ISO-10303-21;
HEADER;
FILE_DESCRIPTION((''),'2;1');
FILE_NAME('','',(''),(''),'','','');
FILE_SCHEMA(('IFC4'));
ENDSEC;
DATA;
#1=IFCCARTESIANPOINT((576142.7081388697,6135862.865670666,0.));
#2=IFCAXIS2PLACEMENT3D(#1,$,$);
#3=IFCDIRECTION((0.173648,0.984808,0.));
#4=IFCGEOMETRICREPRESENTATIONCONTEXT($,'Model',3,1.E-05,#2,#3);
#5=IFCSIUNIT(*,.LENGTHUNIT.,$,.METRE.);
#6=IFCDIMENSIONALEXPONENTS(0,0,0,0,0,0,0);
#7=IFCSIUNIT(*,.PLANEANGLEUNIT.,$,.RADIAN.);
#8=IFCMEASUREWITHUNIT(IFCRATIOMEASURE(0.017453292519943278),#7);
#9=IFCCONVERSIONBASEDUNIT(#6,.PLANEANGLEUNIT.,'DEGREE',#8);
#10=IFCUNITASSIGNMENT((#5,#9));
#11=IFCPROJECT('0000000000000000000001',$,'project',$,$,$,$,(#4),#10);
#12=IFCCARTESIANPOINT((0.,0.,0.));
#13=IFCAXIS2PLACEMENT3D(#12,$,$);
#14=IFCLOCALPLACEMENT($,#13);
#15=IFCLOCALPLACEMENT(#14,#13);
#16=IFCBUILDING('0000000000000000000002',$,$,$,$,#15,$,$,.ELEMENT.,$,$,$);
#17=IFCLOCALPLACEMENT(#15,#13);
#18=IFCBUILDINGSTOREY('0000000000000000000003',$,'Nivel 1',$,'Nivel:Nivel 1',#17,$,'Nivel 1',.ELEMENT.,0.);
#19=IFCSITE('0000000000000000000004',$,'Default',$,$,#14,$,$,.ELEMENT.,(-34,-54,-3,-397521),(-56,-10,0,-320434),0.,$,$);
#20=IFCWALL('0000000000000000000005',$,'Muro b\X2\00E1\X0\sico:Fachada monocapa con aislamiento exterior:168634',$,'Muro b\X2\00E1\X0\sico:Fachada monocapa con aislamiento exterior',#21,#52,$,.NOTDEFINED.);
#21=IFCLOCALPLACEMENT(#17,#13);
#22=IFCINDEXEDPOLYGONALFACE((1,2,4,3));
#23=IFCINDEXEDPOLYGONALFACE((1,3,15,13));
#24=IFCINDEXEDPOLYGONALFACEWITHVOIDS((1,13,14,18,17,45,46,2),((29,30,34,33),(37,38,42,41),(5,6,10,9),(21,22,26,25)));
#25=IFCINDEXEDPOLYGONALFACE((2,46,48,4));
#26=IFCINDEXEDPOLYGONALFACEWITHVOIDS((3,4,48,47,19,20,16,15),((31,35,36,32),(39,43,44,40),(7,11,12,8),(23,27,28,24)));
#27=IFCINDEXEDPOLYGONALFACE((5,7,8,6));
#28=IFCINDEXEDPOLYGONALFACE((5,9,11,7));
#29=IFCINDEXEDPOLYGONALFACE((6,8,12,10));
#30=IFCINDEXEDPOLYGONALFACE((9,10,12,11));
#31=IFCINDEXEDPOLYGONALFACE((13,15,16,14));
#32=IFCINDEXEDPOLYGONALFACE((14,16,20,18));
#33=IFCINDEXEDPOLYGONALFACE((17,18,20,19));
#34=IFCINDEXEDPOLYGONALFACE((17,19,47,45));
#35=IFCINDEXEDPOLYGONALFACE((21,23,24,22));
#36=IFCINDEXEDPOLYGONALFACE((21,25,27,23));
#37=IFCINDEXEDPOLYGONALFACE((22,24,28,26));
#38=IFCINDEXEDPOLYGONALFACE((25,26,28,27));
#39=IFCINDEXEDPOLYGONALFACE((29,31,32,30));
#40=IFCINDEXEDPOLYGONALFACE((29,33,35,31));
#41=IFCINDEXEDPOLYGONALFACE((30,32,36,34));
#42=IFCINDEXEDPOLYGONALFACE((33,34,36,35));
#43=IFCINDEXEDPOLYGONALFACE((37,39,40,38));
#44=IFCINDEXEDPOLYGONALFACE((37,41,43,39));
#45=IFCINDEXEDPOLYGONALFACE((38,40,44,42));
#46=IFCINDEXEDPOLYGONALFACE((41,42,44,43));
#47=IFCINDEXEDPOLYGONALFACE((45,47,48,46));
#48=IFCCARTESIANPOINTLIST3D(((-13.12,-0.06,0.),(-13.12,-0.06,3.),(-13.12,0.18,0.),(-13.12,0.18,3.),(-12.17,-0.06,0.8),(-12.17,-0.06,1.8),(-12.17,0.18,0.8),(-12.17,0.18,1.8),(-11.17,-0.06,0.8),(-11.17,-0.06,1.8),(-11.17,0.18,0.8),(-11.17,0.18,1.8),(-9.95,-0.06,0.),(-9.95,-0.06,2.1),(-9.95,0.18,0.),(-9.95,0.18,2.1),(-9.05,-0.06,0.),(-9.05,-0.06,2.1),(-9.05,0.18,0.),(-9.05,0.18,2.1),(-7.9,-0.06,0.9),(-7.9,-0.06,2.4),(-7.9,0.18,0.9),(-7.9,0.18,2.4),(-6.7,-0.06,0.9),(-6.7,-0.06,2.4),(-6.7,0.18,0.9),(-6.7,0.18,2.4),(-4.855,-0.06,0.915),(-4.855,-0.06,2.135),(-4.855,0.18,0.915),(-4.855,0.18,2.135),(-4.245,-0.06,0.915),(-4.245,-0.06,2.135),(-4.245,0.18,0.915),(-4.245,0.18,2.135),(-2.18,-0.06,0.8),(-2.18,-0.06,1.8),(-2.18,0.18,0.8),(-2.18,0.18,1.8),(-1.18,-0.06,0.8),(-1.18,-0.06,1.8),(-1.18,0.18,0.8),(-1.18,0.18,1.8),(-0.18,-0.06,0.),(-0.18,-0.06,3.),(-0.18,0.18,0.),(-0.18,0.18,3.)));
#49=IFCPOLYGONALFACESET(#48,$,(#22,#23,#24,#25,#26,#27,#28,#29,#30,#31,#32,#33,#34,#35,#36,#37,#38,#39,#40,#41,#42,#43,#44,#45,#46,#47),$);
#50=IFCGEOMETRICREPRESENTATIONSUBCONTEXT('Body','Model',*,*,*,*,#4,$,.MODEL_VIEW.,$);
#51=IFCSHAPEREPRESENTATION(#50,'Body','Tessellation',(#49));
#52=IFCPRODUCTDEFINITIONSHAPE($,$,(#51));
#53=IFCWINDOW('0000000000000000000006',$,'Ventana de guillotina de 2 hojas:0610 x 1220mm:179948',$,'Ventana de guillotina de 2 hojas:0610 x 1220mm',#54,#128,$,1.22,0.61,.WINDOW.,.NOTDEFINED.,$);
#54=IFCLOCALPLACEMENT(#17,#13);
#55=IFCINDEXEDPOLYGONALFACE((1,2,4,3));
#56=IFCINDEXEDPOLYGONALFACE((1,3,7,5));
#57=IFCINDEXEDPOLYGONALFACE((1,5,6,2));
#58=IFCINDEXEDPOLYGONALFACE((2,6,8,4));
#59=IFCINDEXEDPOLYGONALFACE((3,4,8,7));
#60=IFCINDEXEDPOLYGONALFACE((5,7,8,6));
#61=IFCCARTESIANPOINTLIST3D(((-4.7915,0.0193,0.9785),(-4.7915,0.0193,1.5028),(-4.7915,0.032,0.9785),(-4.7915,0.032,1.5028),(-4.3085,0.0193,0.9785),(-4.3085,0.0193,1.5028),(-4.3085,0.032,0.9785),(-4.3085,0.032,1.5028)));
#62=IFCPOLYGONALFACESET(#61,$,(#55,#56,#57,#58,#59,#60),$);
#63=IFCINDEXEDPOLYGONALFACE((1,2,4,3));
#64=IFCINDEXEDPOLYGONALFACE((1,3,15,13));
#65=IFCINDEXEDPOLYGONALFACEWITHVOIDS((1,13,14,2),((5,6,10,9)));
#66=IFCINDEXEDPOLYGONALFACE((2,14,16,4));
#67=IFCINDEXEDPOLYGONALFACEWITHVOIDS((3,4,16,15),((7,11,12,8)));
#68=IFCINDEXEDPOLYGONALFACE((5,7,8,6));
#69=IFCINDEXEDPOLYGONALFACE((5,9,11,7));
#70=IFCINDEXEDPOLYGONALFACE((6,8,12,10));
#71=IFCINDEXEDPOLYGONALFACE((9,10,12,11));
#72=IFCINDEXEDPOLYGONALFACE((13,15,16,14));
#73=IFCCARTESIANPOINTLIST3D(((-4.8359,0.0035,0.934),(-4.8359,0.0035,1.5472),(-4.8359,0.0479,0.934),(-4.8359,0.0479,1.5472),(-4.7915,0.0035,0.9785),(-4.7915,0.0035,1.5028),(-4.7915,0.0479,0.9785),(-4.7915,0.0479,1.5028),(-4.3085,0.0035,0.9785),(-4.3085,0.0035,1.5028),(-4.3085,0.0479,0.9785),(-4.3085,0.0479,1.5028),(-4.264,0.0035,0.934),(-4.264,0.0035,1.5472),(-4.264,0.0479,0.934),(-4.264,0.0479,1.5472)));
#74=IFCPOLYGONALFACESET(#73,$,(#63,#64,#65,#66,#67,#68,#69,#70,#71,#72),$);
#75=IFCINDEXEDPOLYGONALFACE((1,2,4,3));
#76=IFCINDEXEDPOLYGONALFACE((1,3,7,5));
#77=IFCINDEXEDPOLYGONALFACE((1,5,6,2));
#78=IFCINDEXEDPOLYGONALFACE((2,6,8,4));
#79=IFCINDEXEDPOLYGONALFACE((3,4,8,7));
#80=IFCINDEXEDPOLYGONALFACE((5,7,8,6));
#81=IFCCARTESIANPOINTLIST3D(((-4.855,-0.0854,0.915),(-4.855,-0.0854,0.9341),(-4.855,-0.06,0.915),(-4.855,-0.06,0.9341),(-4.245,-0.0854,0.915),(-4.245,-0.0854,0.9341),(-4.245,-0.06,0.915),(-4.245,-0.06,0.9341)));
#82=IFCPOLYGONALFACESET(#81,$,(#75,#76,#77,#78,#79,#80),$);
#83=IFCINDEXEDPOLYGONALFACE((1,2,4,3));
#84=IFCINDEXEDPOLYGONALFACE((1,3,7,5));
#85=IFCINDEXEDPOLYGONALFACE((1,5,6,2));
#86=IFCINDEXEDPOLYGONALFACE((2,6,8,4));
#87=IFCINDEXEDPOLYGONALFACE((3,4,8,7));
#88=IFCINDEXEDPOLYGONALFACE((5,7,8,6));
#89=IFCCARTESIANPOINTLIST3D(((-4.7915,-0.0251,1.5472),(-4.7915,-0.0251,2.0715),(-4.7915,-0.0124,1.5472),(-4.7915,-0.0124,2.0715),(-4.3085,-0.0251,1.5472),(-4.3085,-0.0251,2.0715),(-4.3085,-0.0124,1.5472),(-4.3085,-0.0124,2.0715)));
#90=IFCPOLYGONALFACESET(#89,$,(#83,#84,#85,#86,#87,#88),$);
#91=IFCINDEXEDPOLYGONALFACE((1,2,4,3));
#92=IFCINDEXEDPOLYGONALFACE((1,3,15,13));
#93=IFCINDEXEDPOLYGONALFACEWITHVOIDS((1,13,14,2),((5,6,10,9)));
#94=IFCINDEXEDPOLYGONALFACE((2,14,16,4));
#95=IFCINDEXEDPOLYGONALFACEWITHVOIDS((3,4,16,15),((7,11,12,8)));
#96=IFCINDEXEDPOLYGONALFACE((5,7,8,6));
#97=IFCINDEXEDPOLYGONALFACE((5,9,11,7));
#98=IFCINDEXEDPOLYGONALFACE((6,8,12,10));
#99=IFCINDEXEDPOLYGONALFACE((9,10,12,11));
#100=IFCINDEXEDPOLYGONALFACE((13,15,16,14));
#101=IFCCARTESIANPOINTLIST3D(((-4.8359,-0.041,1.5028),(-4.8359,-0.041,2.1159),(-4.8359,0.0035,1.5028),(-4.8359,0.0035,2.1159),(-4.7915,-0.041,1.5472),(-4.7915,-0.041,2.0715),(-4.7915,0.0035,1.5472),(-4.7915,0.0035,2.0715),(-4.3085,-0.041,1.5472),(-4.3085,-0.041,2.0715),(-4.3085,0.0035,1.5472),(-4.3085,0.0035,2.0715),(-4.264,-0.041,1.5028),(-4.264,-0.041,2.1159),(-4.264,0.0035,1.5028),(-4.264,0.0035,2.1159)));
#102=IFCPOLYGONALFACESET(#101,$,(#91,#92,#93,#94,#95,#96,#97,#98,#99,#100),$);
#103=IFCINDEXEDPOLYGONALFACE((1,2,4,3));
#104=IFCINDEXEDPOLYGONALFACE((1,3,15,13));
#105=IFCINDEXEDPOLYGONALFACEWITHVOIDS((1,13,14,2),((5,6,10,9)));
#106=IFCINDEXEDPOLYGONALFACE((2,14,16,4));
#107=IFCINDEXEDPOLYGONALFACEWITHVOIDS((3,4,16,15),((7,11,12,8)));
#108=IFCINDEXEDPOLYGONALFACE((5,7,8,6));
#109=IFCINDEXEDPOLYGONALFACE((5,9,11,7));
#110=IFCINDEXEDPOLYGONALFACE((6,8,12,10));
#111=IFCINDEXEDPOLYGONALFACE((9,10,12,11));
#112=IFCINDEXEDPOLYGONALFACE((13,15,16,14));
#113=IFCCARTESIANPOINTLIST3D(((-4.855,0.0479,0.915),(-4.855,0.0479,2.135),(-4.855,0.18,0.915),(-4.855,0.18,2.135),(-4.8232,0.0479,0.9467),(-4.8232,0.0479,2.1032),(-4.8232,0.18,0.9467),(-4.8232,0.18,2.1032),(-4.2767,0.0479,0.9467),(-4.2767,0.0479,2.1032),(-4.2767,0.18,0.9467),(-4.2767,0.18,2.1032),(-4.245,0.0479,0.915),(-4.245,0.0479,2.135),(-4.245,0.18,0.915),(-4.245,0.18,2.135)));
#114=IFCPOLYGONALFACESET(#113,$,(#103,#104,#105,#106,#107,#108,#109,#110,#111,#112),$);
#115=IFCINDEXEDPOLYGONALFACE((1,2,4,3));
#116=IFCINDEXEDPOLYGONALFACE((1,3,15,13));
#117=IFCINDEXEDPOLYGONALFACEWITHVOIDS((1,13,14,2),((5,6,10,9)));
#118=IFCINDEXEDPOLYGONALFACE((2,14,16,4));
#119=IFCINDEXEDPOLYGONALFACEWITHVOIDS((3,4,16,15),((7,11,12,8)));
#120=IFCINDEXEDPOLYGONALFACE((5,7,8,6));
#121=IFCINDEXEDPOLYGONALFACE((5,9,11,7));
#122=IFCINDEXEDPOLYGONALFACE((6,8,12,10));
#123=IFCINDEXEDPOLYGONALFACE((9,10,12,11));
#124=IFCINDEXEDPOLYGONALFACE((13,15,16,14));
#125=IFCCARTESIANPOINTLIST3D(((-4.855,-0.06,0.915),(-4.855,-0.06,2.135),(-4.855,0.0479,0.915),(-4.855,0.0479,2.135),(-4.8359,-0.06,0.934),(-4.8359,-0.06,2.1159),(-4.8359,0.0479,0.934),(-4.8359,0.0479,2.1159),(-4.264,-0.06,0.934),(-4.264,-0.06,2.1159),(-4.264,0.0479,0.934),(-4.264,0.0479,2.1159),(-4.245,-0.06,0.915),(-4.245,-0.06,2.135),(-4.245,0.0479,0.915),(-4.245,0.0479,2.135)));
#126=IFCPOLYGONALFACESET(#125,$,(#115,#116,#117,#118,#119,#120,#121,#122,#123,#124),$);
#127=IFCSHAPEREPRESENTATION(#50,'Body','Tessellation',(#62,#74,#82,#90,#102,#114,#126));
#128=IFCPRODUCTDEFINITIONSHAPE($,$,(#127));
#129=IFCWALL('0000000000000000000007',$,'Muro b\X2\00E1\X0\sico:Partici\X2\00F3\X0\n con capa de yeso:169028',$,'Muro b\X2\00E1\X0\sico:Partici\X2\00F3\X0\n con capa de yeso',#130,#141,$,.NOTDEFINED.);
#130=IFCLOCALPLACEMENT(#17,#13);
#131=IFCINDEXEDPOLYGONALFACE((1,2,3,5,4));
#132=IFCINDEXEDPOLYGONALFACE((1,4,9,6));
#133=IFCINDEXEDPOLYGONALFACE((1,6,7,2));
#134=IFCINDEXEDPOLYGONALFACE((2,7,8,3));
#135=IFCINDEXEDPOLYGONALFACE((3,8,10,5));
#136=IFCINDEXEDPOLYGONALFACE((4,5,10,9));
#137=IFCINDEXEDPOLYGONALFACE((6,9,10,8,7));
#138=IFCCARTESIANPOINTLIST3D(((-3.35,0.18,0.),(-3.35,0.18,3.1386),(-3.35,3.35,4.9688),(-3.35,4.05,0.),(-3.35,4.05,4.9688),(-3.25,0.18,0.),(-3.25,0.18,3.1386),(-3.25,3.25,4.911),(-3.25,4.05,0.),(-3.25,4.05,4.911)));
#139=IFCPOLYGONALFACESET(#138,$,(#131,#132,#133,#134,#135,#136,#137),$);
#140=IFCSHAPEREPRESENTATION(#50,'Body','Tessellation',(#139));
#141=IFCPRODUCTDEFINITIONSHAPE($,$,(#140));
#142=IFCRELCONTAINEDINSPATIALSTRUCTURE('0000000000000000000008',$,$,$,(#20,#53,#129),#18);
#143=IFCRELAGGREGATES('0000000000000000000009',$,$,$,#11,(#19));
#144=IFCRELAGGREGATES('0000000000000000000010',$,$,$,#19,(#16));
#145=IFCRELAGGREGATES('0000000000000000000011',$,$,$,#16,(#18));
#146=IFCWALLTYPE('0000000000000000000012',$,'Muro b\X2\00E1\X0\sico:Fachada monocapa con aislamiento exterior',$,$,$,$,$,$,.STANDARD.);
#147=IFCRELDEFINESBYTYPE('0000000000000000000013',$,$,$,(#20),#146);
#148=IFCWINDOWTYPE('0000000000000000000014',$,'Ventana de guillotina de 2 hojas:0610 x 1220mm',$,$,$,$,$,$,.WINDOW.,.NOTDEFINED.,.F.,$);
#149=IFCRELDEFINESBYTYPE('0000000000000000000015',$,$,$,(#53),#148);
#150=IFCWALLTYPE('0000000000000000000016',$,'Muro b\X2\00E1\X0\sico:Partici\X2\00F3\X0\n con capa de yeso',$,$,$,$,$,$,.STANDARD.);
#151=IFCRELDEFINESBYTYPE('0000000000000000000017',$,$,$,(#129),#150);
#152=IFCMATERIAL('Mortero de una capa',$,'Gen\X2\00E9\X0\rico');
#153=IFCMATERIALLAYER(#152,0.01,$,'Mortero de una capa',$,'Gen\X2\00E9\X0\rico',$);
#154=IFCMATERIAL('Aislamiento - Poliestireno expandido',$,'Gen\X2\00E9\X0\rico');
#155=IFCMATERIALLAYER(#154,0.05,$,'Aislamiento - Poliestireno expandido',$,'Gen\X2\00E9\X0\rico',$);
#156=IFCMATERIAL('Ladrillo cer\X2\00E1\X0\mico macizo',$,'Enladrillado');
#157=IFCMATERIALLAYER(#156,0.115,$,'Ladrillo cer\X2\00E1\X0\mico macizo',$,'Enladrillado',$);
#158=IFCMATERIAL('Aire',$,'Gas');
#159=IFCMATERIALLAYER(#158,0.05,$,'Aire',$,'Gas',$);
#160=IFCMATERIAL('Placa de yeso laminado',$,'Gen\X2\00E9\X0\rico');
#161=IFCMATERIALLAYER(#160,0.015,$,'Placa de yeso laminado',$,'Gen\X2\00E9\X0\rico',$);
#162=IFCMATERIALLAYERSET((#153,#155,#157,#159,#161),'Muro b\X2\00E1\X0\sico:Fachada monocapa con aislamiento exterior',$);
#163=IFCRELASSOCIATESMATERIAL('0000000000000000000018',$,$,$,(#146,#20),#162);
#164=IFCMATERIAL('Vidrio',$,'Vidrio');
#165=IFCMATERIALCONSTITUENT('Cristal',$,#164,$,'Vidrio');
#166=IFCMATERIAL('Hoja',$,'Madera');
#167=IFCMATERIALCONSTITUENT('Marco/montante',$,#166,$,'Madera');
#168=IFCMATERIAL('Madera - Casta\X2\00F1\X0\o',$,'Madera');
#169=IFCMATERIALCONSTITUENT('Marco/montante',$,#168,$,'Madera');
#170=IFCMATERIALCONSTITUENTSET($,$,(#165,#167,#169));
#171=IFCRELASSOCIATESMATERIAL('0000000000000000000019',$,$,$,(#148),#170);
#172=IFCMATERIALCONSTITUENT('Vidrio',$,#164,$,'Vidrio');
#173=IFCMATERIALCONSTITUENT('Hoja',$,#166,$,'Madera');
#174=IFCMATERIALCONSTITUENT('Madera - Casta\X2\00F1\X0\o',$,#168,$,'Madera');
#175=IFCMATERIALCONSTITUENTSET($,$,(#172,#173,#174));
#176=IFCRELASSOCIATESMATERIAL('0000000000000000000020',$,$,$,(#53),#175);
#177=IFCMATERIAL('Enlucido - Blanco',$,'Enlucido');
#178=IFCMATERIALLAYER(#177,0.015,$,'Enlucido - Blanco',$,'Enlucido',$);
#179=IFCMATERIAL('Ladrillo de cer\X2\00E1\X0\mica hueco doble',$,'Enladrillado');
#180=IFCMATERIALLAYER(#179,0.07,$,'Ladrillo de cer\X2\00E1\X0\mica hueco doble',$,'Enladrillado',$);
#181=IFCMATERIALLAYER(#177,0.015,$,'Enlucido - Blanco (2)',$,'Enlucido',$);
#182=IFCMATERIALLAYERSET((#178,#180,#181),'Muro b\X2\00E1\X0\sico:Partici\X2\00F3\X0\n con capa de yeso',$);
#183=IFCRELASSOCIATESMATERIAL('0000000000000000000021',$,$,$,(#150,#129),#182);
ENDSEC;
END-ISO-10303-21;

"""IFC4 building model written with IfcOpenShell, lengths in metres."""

from ifc_helpers import new_model, entity, si_unit, converted_unit, direction, frame, frame_2d, origin, place, context, subcontext, project, spatial, polyline, rectangle, outline, extrude, clip, bounded_halfspace, source, transform, mapped, material, layer, layer_set, layer_usage, constituent, constituent_set, type_object, type_shapes, element, fill, save


model = new_model("IFC4")

# Units and contexts
model_context = context("Model", 3, precision=1e-05, world=frame((576142.7081388697, 6135862.865670666, 0.0)), true_north=direction((0.173648, 0.984808, 0.0)))
body_context = subcontext(model_context, "Body", "Model", "MODEL_VIEW")
ifc_project = project(units=[si_unit("LENGTHUNIT", "METRE"), converted_unit("PLANEANGLEUNIT", "DEGREE", entity("IfcRatioMeasure", 0.017453292519943278), si_unit("PLANEANGLEUNIT", "RADIAN"), dimensions=[0, 0, 0, 0, 0, 0, 0])], contexts=[model_context])

# Site, building, storey
site_placement = place(None, origin())
site = spatial("IfcSite", under=ifc_project, at=site_placement, Name="Default", CompositionType="ELEMENT", RefLatitude=(-34, -54, -3, -397521), RefLongitude=(-56, -10, 0, -320434), RefElevation=0.0)
building_placement = place(site_placement, origin())
building = spatial("IfcBuilding", under=site, at=building_placement, CompositionType="ELEMENT")
storey_placement = place(building_placement, origin())
storey = spatial("IfcBuildingStorey", under=building, at=storey_placement, Name="Nivel 1", ObjectType="Nivel:Nivel 1", LongName="Nivel 1", CompositionType="ELEMENT", Elevation=0.0)

# Shared definitions
ifc_material_1 = material(Name="Mortero de una capa", Category="Genérico")
ifc_layer_1 = layer(ifc_material_1, 0.01, Name="Mortero de una capa", Category="Genérico")
ifc_material_2 = material(Name="Aislamiento - Poliestireno expandido", Category="Genérico")
ifc_layer_2 = layer(ifc_material_2, 0.05, Name="Aislamiento - Poliestireno expandido", Category="Genérico")
ifc_material_3 = material(Name="Ladrillo cerámico macizo", Category="Enladrillado")
ifc_layer_3 = layer(ifc_material_3, 0.115, Name="Ladrillo cerámico macizo", Category="Enladrillado")
ifc_material_4 = material(Name="Aire", Category="Gas")
ifc_layer_4 = layer(ifc_material_4, 0.05, Name="Aire", Category="Gas")
ifc_material_5 = material(Name="Placa de yeso laminado", Category="Genérico")
ifc_layer_5 = layer(ifc_material_5, 0.015, Name="Placa de yeso laminado", Category="Genérico")
ifc_layer_set_1 = layer_set([ifc_layer_1, ifc_layer_2, ifc_layer_3, ifc_layer_4, ifc_layer_5], Name="Muro básico:Fachada monocapa con aislamiento exterior")
ifc_layer_usage_1 = layer_usage(ifc_layer_set_1, "AXIS2", "NEGATIVE", 0.12)
wall_type_1 = type_object("IfcWallType", Name="Muro básico:Fachada monocapa con aislamiento exterior", PredefinedType="STANDARD", material=ifc_layer_set_1)

# Wall, openings, window
wall_1_placement = place(storey_placement, frame((-0.18, 0.06, 0.0), z_axis=(0.0, 0.0, 1.0), x_axis=(-1.0, 0.0, 0.0)))
wall_1 = element("IfcWall", 1, at=wall_1_placement, inside=storey, type_object=wall_type_1, material=ifc_layer_usage_1, Name="Muro básico:Fachada monocapa con aislamiento exterior:168634", ObjectType="Muro básico:Fachada monocapa con aislamiento exterior", PredefinedType="NOTDEFINED", context=body_context, shape_type="SweptSolid", body=[
    extrude(rectangle(XDim=12.94, YDim=0.24, at=frame_2d((6.47, 0.0), x_axis=(-1.0, 0.0))), origin(), (0.0, 0.0, 1.0), 3.0),
])
opening_1_placement = place(wall_1_placement, frame((9.77, 0.12, 0.0)))
element("IfcOpeningElement", 2, at=opening_1_placement, cuts=wall_1, PredefinedType="OPENING", context=body_context, shape_type="SweptSolid", body=[
    extrude(rectangle(XDim=2.1, YDim=0.9, at=frame_2d((1.05, 0.45), x_axis=(1.0, 0.0))), frame((0.0, 0.0, 0.0), z_axis=(0.0, -1.0, 0.0), x_axis=(0.0, 0.0, 1.0)), (0.0, 0.0, 1.0), 0.24),
])
opening_2_placement = place(wall_1_placement, frame((10.99, -0.12, 0.8)))
element("IfcOpeningElement", 3, at=opening_2_placement, cuts=wall_1, PredefinedType="OPENING", context=body_context, shape_type="SweptSolid", body=[
    extrude(rectangle(XDim=1.0, YDim=1.0, at=frame_2d((0.5, 0.5), x_axis=(1.0, 0.0))), frame((0.0, 0.0, 0.0), z_axis=(0.0, 1.0, 0.0), x_axis=(0.0, 0.0, 1.0)), (0.0, 0.0, 1.0), 0.24),
])
opening_3_placement = place(wall_1_placement, frame((1.0, -0.12, 0.8)))
element("IfcOpeningElement", 4, at=opening_3_placement, cuts=wall_1, PredefinedType="OPENING", context=body_context, shape_type="SweptSolid", body=[
    extrude(rectangle(XDim=1.0, YDim=1.0, at=frame_2d((0.5, 0.5), x_axis=(1.0, 0.0))), frame((0.0, 0.0, 0.0), z_axis=(0.0, 1.0, 0.0), x_axis=(0.0, 0.0, 1.0)), (0.0, 0.0, 1.0), 0.24),
])
opening_4_placement = place(wall_1_placement, frame((4.065, -0.12, 0.915)))
opening_4 = element("IfcOpeningElement", 5, at=opening_4_placement, cuts=wall_1, PredefinedType="OPENING", context=body_context, shape_type="SweptSolid", body=[
    extrude(rectangle(XDim=1.22, YDim=0.61, at=frame_2d((0.61, 0.305), x_axis=(-1.0, 0.0))), frame((0.0, 0.0, 0.0), z_axis=(0.0, 1.0, 0.0), x_axis=(0.0, 0.0, 1.0)), (0.0, 0.0, 1.0), 0.24),
])
opening_5_placement = place(wall_1_placement, frame((6.52, -0.12, 0.9)))
element("IfcOpeningElement", 6, at=opening_5_placement, cuts=wall_1, PredefinedType="OPENING", context=body_context, shape_type="SweptSolid", body=[
    extrude(rectangle(XDim=1.5, YDim=1.2, at=frame_2d((0.75, 0.6), x_axis=(1.0, 0.0))), frame((0.0, 0.0, 0.0), z_axis=(0.0, 1.0, 0.0), x_axis=(0.0, 0.0, 1.0)), (0.0, 0.0, 1.0), 0.24),
])
ifc_material_6 = material(Name="Vidrio", Category="Vidrio")
ifc_constituent_1 = constituent(ifc_material_6, Name="Vidrio", Category="Vidrio")
ifc_material_7 = material(Name="Hoja", Category="Madera")
ifc_constituent_2 = constituent(ifc_material_7, Name="Hoja", Category="Madera")
ifc_material_8 = material(Name="Madera - Castaño", Category="Madera")
ifc_constituent_3 = constituent(ifc_material_8, Name="Madera - Castaño", Category="Madera")
ifc_constituent_set_1 = constituent_set(constituents=[ifc_constituent_1, ifc_constituent_2, ifc_constituent_3])
ifc_constituent_4 = constituent(ifc_material_6, Name="Cristal", Category="Vidrio")
ifc_constituent_5 = constituent(ifc_material_7, Name="Marco/montante", Category="Madera")
ifc_constituent_6 = constituent(ifc_material_8, Name="Marco/montante", Category="Madera")
ifc_constituent_set_2 = constituent_set(constituents=[ifc_constituent_4, ifc_constituent_5, ifc_constituent_6])
window_type = type_object("IfcWindowType", Name="Ventana de guillotina de 2 hojas:0610 x 1220mm", ParameterTakesPrecedence=False, PartitioningType="NOTDEFINED", PredefinedType="WINDOW", material=ifc_constituent_set_2)
shared_shape_1 = source(origin(), body_context, "Body", "SweptSolid", [
    extrude(rectangle(XDim=0.0127, YDim=0.483, at=frame_2d((0.0, 0.0), x_axis=(1.0, 0.0))), frame((0.305, 0.1543, 0.0635), z_axis=(0.0, 0.0, 1.0), x_axis=(0.0, -1.0, 0.0)), (0.0, 0.0, 1.0), 0.5243),
    extrude(outline(polyline([(-0.286, -0.3066), (0.286, -0.3066), (0.286, 0.3066), (-0.286, 0.3066), (-0.286, -0.3066)]), holes=[polyline([(-0.2415, -0.2621), (-0.2415, 0.2621), (0.2415, 0.2621), (0.2415, -0.2621), (-0.2415, -0.2621)])]), frame((0.305, 0.1321, 0.3256), z_axis=(0.0, 1.0, 0.0), x_axis=(1.0, 0.0, 0.0)), (0.0, 0.0, 1.0), 0.0445),
    extrude(rectangle(XDim=0.0254, YDim=0.61, at=frame_2d((0.0, 0.0), x_axis=(1.0, 0.0))), frame((0.305, 0.2527, 0.0), z_axis=(0.0, 0.0, 1.0), x_axis=(0.0, -1.0, 0.0)), (0.0, 0.0, 1.0), 0.0191),
    extrude(rectangle(XDim=0.0127, YDim=0.483, at=frame_2d((0.0, 0.0), x_axis=(1.0, 0.0))), frame((0.305, 0.1988, 0.6322), z_axis=(0.0, 0.0, 1.0), x_axis=(0.0, 1.0, 0.0)), (0.0, 0.0, 1.0), 0.5243),
    extrude(outline(polyline([(-0.2859, -0.3066), (0.2859, -0.3066), (0.2859, 0.3066), (-0.2859, 0.3066), (-0.2859, -0.3066)]), holes=[polyline([(-0.2415, -0.2621), (-0.2415, 0.2621), (0.2415, 0.2621), (0.2415, -0.2621), (-0.2415, -0.2621)])]), frame((0.305, 0.1765, 0.8944), z_axis=(0.0, 1.0, 0.0), x_axis=(1.0, 0.0, 0.0)), (0.0, 0.0, 1.0), 0.0444),
    extrude(outline(polyline([(-0.305, -0.61), (0.305, -0.61), (0.305, 0.61), (-0.305, 0.61), (-0.305, -0.61)]), holes=[polyline([(-0.2733, -0.5782), (-0.2733, 0.5783), (0.2732, 0.5783), (0.2732, -0.5782), (-0.2733, -0.5782)])]), frame((0.305, 0.0, 0.61), z_axis=(0.0, 1.0, 0.0), x_axis=(1.0, 0.0, 0.0)), (0.0, 0.0, 1.0), 0.1321),
    extrude(outline(polyline([(-0.61, -0.305), (0.61, -0.305), (0.61, 0.305), (-0.61, 0.305), (-0.61, -0.305)]), holes=[polyline([(-0.591, -0.2859), (-0.591, 0.286), (0.5909, 0.286), (0.5909, -0.2859), (-0.591, -0.2859)])]), frame((0.305, 0.1321, 0.61), z_axis=(0.0, 1.0, 0.0), x_axis=(0.0, 0.0, -1.0)), (0.0, 0.0, 1.0), 0.1079),
])
type_shapes(window_type, [shared_shape_1])
window_placement = place(opening_4_placement, origin())
window = element("IfcWindow", 7, at=window_placement, inside=storey, type_object=window_type, material=ifc_constituent_set_1, Name="Ventana de guillotina de 2 hojas:0610 x 1220mm:179948", ObjectType="Ventana de guillotina de 2 hojas:0610 x 1220mm", OverallHeight=1.22, OverallWidth=0.61, PartitioningType="NOTDEFINED", PredefinedType="WINDOW", context=body_context, shape_type="MappedRepresentation", body=[
    mapped(shared_shape_1, transform((0.0, 0.0, 0.0), scale=1.0)),
])
fill(opening_4, window)

# Wall
ifc_material_9 = material(Name="Enlucido - Blanco", Category="Enlucido")
ifc_layer_6 = layer(ifc_material_9, 0.015, Name="Enlucido - Blanco", Category="Enlucido")
ifc_material_10 = material(Name="Ladrillo de cerámica hueco doble", Category="Enladrillado")
ifc_layer_7 = layer(ifc_material_10, 0.07, Name="Ladrillo de cerámica hueco doble", Category="Enladrillado")
ifc_layer_8 = layer(ifc_material_9, 0.015, Name="Enlucido - Blanco (2)", Category="Enlucido")
ifc_layer_set_2 = layer_set([ifc_layer_6, ifc_layer_7, ifc_layer_8], Name="Muro básico:Partición con capa de yeso")
ifc_layer_usage_2 = layer_usage(ifc_layer_set_2, "AXIS2", "NEGATIVE", 0.05)
wall_type_2 = type_object("IfcWallType", Name="Muro básico:Partición con capa de yeso", PredefinedType="STANDARD", material=ifc_layer_set_2)
wall_2_placement = place(storey_placement, frame((-3.3, 0.18, 0.0), z_axis=(0.0, 0.0, 1.0), x_axis=(0.0, 1.0, 0.0)))
element("IfcWall", 8, at=wall_2_placement, inside=storey, type_object=wall_type_2, material=ifc_layer_usage_2, Name="Muro básico:Partición con capa de yeso:169028", ObjectType="Muro básico:Partición con capa de yeso", PredefinedType="NOTDEFINED", context=body_context, shape_type="Clipping", body=[
    clip(clip(extrude(rectangle(XDim=3.87, YDim=0.1, at=frame_2d((1.935, 0.0), x_axis=(-1.0, 0.0))), origin(), (0.0, 0.0, 1.0), 4.9688), bounded_halfspace(frame((3.07, -0.05, 4.911), z_axis=(0.0, -0.5, 0.866025), x_axis=(1.0, 0.0, 0.0)), False, frame((3.07, -0.05, 4.911)), polyline([(0.0, 0.0), (0.8, 0.0), (0.8, 0.1), (0.1, 0.1), (0.0, 0.0)]))), bounded_halfspace(frame((0.0, -0.05, 3.1386), z_axis=(-0.5, 0.0, 0.866025), x_axis=(0.0, -1.0, 0.0)), False, frame((0.0, -0.05, 3.1386)), polyline([(0.0, 0.0), (3.07, 0.0), (3.17, 0.1), (0.0, 0.1), (0.0, 0.0)]))),
])

save(model, "model.ifc")
